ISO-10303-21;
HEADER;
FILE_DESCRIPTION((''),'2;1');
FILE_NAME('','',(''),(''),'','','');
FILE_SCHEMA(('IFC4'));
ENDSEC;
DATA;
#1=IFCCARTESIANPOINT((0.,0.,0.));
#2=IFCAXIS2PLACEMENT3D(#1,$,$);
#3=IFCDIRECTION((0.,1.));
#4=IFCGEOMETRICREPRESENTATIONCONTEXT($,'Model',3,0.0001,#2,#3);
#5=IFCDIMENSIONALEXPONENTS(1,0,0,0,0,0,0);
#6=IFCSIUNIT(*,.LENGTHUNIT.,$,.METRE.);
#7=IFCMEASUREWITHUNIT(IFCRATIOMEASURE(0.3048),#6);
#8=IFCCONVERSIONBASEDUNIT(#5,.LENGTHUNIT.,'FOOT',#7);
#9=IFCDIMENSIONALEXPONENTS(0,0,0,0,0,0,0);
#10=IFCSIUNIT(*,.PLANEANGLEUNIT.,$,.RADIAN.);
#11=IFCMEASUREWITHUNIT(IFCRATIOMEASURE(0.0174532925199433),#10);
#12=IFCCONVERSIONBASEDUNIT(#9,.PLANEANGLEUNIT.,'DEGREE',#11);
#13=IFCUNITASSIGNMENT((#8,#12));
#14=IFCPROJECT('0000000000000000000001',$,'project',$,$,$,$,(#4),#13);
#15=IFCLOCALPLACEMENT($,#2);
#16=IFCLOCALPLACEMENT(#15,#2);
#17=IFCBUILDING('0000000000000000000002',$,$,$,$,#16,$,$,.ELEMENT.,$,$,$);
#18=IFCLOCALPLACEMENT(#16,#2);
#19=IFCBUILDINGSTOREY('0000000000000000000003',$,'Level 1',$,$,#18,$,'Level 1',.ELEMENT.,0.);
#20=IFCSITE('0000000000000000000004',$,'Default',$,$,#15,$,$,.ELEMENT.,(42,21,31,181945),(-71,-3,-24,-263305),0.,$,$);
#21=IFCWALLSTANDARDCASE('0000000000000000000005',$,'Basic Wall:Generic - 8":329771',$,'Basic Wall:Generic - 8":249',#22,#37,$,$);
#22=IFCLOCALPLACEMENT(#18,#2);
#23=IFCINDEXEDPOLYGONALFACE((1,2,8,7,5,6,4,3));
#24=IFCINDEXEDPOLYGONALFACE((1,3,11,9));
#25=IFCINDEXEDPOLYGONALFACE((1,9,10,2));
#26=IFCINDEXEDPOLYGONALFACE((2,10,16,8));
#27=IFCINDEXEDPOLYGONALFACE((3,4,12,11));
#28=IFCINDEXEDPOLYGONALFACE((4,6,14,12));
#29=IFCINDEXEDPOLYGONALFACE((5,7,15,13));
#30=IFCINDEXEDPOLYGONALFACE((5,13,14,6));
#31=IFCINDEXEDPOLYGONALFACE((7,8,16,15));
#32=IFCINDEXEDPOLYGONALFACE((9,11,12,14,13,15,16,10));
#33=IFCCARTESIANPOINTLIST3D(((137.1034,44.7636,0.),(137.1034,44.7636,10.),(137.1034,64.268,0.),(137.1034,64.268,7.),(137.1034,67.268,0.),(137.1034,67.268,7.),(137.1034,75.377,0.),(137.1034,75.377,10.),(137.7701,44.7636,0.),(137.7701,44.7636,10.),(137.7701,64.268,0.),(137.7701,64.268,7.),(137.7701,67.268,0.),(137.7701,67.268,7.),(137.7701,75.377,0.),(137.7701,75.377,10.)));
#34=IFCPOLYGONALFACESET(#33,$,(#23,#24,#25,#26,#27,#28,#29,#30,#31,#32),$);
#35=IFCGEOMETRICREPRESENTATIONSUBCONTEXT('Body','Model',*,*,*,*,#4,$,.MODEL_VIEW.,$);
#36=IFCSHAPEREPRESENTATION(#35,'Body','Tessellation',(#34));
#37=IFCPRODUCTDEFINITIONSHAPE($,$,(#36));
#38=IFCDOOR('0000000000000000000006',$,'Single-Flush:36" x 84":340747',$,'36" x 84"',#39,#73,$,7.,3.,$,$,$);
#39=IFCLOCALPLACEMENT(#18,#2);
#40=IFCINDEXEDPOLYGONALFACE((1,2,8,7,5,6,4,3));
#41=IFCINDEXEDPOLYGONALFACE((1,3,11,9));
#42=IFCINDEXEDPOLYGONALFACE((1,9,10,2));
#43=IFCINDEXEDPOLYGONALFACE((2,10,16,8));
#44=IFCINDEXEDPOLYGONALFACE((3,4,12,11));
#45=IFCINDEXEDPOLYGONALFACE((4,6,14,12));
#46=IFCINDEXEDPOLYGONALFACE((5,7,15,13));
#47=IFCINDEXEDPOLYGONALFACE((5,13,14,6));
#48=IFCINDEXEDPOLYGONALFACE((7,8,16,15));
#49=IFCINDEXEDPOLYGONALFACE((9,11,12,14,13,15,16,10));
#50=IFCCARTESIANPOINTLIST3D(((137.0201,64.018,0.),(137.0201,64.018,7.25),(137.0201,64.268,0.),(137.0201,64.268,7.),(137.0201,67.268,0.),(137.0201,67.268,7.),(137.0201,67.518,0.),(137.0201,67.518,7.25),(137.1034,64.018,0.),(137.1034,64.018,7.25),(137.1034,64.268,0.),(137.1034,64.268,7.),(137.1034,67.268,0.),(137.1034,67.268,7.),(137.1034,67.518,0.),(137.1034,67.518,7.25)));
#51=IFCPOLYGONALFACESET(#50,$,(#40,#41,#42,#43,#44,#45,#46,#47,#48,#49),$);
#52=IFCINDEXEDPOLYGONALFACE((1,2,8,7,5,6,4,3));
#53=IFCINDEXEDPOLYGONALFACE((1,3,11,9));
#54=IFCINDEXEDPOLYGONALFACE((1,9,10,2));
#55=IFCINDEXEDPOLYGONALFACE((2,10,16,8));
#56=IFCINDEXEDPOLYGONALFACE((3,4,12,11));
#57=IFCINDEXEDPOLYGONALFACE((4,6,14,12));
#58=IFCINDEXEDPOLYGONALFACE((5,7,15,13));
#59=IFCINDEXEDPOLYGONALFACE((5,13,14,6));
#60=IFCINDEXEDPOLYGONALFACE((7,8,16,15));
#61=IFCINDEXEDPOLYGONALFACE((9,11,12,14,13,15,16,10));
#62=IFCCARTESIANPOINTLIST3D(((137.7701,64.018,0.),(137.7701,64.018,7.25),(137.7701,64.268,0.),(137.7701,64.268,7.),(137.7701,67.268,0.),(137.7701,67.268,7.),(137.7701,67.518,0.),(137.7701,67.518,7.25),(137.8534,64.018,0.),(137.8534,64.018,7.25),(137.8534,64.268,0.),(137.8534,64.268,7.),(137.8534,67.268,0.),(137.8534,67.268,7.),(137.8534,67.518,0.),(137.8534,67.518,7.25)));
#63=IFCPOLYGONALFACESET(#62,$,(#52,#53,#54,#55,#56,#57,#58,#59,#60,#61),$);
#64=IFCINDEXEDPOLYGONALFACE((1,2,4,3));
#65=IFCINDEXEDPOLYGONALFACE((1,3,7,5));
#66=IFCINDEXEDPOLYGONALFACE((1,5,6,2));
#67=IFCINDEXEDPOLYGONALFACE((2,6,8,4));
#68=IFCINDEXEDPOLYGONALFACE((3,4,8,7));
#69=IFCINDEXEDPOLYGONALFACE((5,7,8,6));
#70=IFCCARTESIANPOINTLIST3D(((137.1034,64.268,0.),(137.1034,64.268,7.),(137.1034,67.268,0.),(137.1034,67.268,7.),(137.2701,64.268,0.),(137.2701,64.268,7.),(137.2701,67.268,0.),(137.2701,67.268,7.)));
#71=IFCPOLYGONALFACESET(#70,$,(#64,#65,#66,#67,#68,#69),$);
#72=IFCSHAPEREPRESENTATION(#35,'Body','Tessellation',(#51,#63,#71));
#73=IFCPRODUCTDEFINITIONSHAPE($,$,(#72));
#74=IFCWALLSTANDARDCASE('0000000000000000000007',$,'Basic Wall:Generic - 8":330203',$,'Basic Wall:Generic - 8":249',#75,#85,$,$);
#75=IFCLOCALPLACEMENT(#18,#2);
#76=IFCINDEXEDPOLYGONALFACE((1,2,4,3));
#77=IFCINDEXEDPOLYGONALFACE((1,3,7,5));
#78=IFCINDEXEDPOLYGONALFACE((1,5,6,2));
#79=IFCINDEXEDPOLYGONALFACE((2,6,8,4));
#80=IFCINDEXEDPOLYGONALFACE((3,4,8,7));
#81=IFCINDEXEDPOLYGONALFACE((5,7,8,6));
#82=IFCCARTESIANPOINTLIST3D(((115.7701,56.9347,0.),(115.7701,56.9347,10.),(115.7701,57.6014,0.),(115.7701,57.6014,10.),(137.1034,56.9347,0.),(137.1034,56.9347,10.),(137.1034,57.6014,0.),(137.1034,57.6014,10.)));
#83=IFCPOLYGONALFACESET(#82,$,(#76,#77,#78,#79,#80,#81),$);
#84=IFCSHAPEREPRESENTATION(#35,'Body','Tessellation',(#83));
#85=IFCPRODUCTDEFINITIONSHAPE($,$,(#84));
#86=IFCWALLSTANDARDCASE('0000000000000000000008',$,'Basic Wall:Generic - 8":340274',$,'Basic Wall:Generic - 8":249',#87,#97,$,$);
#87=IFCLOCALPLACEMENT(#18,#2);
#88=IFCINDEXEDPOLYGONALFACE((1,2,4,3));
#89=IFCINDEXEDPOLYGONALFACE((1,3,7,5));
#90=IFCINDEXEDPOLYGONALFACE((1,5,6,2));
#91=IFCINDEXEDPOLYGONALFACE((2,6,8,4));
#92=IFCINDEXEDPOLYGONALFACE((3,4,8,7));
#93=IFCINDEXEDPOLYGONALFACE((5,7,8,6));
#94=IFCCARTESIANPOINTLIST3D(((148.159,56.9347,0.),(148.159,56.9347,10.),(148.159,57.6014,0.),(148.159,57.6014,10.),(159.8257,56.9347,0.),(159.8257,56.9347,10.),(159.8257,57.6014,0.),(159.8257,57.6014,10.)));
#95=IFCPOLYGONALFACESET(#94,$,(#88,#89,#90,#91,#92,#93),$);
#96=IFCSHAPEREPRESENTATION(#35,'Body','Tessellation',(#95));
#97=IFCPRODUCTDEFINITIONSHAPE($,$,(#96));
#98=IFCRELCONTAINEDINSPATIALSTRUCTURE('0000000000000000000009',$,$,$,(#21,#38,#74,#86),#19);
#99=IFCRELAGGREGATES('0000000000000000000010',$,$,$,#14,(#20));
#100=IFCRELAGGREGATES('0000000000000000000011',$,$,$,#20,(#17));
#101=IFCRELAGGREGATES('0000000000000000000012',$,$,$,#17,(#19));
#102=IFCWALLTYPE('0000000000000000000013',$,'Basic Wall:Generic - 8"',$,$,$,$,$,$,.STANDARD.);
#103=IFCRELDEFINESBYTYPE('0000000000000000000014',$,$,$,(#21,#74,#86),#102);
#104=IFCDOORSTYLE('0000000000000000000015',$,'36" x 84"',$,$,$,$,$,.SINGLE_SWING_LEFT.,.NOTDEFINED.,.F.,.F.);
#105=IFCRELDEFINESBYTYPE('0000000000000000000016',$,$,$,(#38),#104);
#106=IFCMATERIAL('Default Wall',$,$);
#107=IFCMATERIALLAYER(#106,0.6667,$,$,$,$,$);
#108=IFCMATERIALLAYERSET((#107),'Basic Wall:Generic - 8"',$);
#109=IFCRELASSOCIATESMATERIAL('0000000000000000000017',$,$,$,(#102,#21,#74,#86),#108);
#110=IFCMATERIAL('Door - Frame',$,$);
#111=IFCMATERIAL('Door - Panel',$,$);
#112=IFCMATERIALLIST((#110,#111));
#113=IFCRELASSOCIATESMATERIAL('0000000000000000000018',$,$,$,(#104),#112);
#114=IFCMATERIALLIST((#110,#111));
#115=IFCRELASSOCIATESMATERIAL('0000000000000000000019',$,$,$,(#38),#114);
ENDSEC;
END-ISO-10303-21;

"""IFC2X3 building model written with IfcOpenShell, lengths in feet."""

from ifc_helpers import new_model, entity, si_unit, converted_unit, direction, frame, frame_2d, origin, place, context, subcontext, project, spatial, polyline, rectangle, outline, extrude, source, transform, mapped, material, material_list, layer, layer_set, layer_usage, type_object, type_shapes, element, fill, save


model = new_model("IFC2X3")

# Units and contexts
model_context = context("Model", 3, precision=0.0001, world=origin(), true_north=direction((0.0, 1.0)))
body_context = subcontext(model_context, "Body", "Model", "MODEL_VIEW")
ifc_project = project(units=[converted_unit("LENGTHUNIT", "FOOT", entity("IfcRatioMeasure", 0.3048), si_unit("LENGTHUNIT", "METRE"), dimensions=[1, 0, 0, 0, 0, 0, 0]), converted_unit("PLANEANGLEUNIT", "DEGREE", entity("IfcRatioMeasure", 0.0174532925199433), si_unit("PLANEANGLEUNIT", "RADIAN"), dimensions=[0, 0, 0, 0, 0, 0, 0])], contexts=[model_context])

# Site, building, storey
site_placement = place(None, origin())
site = spatial("IfcSite", under=ifc_project, at=site_placement, Name="Default", CompositionType="ELEMENT", RefLatitude=(42, 21, 31, 181945), RefLongitude=(-71, -3, -24, -263305), RefElevation=0.0)
building_placement = place(site_placement, origin())
building = spatial("IfcBuilding", under=site, at=building_placement, CompositionType="ELEMENT")
storey_placement = place(building_placement, origin())
storey = spatial("IfcBuildingStorey", under=building, at=storey_placement, Name="Level 1", LongName="Level 1", CompositionType="ELEMENT", Elevation=0.0)

# Shared definitions
ifc_material_1 = material(Name="Default Wall")
ifc_layer = layer(ifc_material_1, 0.6667)
ifc_layer_set = layer_set([ifc_layer], Name="Basic Wall:Generic - 8\"")
wall_type = type_object("IfcWallType", Name="Basic Wall:Generic - 8\"", PredefinedType="STANDARD", material=ifc_layer_set)

# Shared definitions
ifc_material_2 = material(Name="Door - Frame")
ifc_material_3 = material(Name="Door - Panel")

# Wall, opening, door
ifc_layer_usage_1 = layer_usage(ifc_layer_set, "AXIS2", "NEGATIVE", 0.3333)
wall_1_placement = place(storey_placement, frame((137.4368, 75.377, 0.0), z_axis=(0.0, 0.0, 1.0), x_axis=(0.0, -1.0, 0.0)))
wall_1 = element("IfcWallStandardCase", 1, at=wall_1_placement, inside=storey, type_object=wall_type, material=ifc_layer_usage_1, Name="Basic Wall:Generic - 8\":329771", ObjectType="Basic Wall:Generic - 8\":249", context=body_context, shape_type="SweptSolid", body=[
    extrude(rectangle(XDim=30.6135, YDim=0.6667, at=frame_2d((15.3067, 0.0), x_axis=(-1.0, 0.0))), origin(), (0.0, 0.0, 1.0), 10.0),
])
opening_1_placement = place(wall_1_placement, frame((11.109, 0.3333, 0.0)))
opening_1 = element("IfcOpeningElement", 2, at=opening_1_placement, cuts=wall_1, ObjectType="Opening", context=body_context, shape_type="SweptSolid", body=[
    extrude(rectangle(XDim=3.0, YDim=7.0, at=frame_2d((3.5, 1.5), x_axis=(0.0, -1.0))), frame((0.0, 0.0, 0.0), z_axis=(0.0, -1.0, 0.0), x_axis=(0.0, 0.0, 1.0)), (0.0, 0.0, 1.0), 0.6667),
])
ifc_material_list_1 = material_list([ifc_material_2, ifc_material_3])
ifc_material_list_2 = material_list([ifc_material_2, ifc_material_3])
door_style_1 = type_object("IfcDoorStyle", Name="36\" x 84\"", ConstructionType="NOTDEFINED", OperationType="SINGLE_SWING_LEFT", ParameterTakesPrecedence=False, Sizeable=False, material=ifc_material_list_2)
shared_shape_1 = source(origin(), body_context, "Body", "SweptSolid", [
    extrude(outline(polyline([(-1.75, -3.6875), (1.75, -3.6875), (1.75, 3.5625), (1.5, 3.5625), (1.5, -3.4375), (-1.5, -3.4375), (-1.5, 3.5625), (-1.75, 3.5625), (-1.75, -3.6875)])), frame((1.5, 0.75, 3.5625), z_axis=(0.0, -1.0, 0.0), x_axis=(-1.0, 0.0, 0.0)), (0.0, 0.0, 1.0), 0.0833),
    extrude(outline(polyline([(-3.6875, -1.75), (3.5625, -1.75), (3.5625, -1.5), (-3.4375, -1.5), (-3.4375, 1.5), (3.5625, 1.5), (3.5625, 1.75), (-3.6875, 1.75), (-3.6875, -1.75)])), frame((1.5, 0.0, 3.5625), z_axis=(0.0, -1.0, 0.0), x_axis=(0.0, 0.0, -1.0)), (0.0, 0.0, 1.0), 0.0833),
    extrude(rectangle(XDim=3.0, YDim=0.1667, at=frame_2d((0.0, 0.0), x_axis=(1.0, 0.0))), frame((1.5, 0.5833, 0.0)), (0.0, 0.0, 1.0), 7.0),
])
type_shapes(door_style_1, [shared_shape_1])
door_1_placement = place(opening_1_placement, frame((0.0, 0.0, 0.0), z_axis=(0.0, 0.0, 1.0), x_axis=(-1.0, 0.0, 0.0)))
door_1 = element("IfcDoor", 3, at=door_1_placement, inside=storey, type_object=door_style_1, material=ifc_material_list_1, Name="Single-Flush:36\" x 84\":340747", ObjectType="36\" x 84\"", OverallHeight=7.0, OverallWidth=3.0, context=body_context, shape_type="MappedRepresentation", body=[
    mapped(shared_shape_1, transform((0.0, 0.0, 0.0), scale=1.0)),
])
fill(opening_1, door_1)

# Walls
ifc_layer_usage_2 = layer_usage(ifc_layer_set, "AXIS2", "NEGATIVE", 0.3333)
wall_2_placement = place(storey_placement, frame((115.7701, 57.268, 0.0)))
element("IfcWallStandardCase", 4, at=wall_2_placement, inside=storey, type_object=wall_type, material=ifc_layer_usage_2, Name="Basic Wall:Generic - 8\":330203", ObjectType="Basic Wall:Generic - 8\":249", context=body_context, shape_type="SweptSolid", body=[
    extrude(rectangle(XDim=21.3333, YDim=0.6667, at=frame_2d((10.6667, 0.0), x_axis=(-1.0, 0.0))), origin(), (0.0, 0.0, 1.0), 10.0),
])
ifc_layer_usage_3 = layer_usage(ifc_layer_set, "AXIS2", "NEGATIVE", 0.3333)
wall_3_placement = place(storey_placement, frame((159.8257, 57.268, 0.0), z_axis=(0.0, 0.0, 1.0), x_axis=(-1.0, 0.0, 0.0)))
element("IfcWallStandardCase", 5, at=wall_3_placement, inside=storey, type_object=wall_type, material=ifc_layer_usage_3, Name="Basic Wall:Generic - 8\":340274", ObjectType="Basic Wall:Generic - 8\":249", context=body_context, shape_type="SweptSolid", body=[
    extrude(rectangle(XDim=11.6667, YDim=0.6667, at=frame_2d((5.8333, 0.0), x_axis=(-1.0, 0.0))), origin(), (0.0, 0.0, 1.0), 10.0),
])

save(model, "model.ifc")
